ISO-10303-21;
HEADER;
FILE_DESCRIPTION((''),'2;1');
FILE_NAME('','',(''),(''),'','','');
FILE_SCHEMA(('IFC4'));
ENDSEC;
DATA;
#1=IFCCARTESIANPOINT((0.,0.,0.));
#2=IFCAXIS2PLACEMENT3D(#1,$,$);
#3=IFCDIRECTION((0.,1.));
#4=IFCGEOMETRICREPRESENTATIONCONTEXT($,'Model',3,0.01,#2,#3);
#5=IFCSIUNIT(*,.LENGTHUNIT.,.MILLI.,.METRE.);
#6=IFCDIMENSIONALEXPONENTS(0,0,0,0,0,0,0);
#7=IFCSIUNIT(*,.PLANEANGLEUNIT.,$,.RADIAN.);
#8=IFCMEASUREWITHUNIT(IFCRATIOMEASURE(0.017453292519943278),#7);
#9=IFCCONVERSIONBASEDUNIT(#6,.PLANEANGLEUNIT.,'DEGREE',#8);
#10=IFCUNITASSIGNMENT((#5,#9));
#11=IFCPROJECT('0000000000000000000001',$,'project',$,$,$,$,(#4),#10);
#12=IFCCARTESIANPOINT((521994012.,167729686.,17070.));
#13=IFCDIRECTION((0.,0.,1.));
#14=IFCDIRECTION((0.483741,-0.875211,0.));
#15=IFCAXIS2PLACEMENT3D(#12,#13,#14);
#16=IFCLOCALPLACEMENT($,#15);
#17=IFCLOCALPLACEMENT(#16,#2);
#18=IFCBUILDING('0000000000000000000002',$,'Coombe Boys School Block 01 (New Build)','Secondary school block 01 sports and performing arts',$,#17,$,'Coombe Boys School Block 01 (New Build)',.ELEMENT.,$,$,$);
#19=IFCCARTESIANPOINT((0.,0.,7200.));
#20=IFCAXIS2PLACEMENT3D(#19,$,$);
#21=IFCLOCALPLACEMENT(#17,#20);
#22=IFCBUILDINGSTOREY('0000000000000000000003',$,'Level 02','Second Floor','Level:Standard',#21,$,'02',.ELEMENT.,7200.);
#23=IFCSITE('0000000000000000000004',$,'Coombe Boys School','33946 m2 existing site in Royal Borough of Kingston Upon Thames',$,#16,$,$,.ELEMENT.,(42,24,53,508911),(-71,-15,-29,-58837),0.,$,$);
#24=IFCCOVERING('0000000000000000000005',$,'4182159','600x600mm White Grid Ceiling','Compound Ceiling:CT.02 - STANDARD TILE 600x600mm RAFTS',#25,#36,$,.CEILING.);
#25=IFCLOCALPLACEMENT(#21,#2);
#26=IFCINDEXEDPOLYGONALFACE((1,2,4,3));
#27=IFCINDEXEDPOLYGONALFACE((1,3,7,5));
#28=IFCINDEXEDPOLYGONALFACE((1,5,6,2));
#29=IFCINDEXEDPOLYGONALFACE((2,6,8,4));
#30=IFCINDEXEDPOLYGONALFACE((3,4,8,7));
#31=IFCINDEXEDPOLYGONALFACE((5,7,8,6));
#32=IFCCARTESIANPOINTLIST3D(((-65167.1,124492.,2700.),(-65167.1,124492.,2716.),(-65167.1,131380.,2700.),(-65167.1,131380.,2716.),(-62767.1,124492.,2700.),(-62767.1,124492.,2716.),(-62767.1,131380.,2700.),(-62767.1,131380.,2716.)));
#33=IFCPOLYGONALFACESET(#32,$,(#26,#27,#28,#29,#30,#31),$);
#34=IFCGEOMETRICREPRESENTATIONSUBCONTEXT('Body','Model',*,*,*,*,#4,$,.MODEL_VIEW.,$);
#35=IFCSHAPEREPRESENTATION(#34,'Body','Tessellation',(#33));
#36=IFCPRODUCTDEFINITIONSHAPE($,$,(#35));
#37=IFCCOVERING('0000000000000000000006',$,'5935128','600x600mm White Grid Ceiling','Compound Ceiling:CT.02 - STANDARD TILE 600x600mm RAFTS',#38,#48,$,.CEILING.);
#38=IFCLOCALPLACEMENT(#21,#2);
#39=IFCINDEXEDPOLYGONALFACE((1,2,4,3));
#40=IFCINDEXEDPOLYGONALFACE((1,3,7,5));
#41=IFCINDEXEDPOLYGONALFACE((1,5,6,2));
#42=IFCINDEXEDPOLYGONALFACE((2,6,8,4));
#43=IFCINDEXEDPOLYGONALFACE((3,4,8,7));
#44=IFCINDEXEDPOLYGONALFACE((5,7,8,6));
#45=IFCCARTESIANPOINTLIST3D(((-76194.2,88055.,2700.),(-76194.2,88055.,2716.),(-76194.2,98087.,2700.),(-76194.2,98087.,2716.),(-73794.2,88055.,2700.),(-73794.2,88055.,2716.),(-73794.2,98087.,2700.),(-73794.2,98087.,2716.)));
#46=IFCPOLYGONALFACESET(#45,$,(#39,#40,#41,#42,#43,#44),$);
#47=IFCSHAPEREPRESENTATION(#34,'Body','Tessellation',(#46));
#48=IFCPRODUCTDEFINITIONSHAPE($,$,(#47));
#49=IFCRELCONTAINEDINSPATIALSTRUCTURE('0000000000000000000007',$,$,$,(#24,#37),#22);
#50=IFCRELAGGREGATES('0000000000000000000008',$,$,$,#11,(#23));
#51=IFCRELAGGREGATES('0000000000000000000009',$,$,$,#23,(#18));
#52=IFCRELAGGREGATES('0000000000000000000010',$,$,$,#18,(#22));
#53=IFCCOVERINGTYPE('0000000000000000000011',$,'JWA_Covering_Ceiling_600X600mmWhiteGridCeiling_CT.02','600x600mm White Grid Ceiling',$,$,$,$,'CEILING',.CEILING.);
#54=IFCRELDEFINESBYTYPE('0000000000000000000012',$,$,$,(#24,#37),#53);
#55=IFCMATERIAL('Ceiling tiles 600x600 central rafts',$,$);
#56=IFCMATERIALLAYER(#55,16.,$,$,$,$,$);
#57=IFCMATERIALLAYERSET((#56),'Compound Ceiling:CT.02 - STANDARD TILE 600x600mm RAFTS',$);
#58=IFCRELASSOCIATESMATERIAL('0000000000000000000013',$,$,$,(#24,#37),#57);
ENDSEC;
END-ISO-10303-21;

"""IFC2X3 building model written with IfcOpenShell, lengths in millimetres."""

from ifc_helpers import new_model, entity, si_unit, converted_unit, direction, frame, frame_2d, origin, place, context, subcontext, project, spatial, rectangle, extrude, material, layer, layer_set, layer_usage, type_object, element, save


model = new_model("IFC2X3")

# Units and contexts
model_context = context("Model", 3, precision=0.01, world=origin(), true_north=direction((0.0, 1.0)))
body_context = subcontext(model_context, "Body", "Model", "MODEL_VIEW")
ifc_project = project(units=[si_unit("LENGTHUNIT", "METRE", prefix="MILLI"), converted_unit("PLANEANGLEUNIT", "DEGREE", entity("IfcRatioMeasure", 0.017453292519943278), si_unit("PLANEANGLEUNIT", "RADIAN"), dimensions=[0, 0, 0, 0, 0, 0, 0])], contexts=[model_context])

# Site, building, storey
site_placement = place(None, frame((521994012.0, 167729686.0, 17070.0), z_axis=(0.0, 0.0, 1.0), x_axis=(0.483741, -0.875211, 0.0)))
site = spatial("IfcSite", under=ifc_project, at=site_placement, Name="Coombe Boys School", Description="33946 m2 existing site in Royal Borough of Kingston Upon Thames", CompositionType="ELEMENT", RefLatitude=(42, 24, 53, 508911), RefLongitude=(-71, -15, -29, -58837), RefElevation=0.0)
building_placement = place(site_placement, origin())
building = spatial("IfcBuilding", under=site, at=building_placement, Name="Coombe Boys School Block 01 (New Build)", Description="Secondary school block 01 sports and performing arts", LongName="Coombe Boys School Block 01 (New Build)", CompositionType="ELEMENT")
storey_placement = place(building_placement, frame((0.0, 0.0, 7200.0)))
storey = spatial("IfcBuildingStorey", under=building, at=storey_placement, Name="Level 02", Description="Second Floor", ObjectType="Level:Standard", LongName="02", CompositionType="ELEMENT", Elevation=7200.0)

# Coverings
ifc_material_1 = material(Name="Ceiling tiles 600x600 central rafts")
ifc_layer_1 = layer(ifc_material_1, 16.0)
ifc_layer_set_1 = layer_set([ifc_layer_1], Name="Compound Ceiling:CT.02 - STANDARD TILE 600x600mm RAFTS")
ifc_layer_usage_1 = layer_usage(ifc_layer_set_1, "AXIS3", "POSITIVE", 0.0)
covering_type_1 = type_object("IfcCoveringType", Name="JWA_Covering_Ceiling_600X600mmWhiteGridCeiling_CT.02", Description="600x600mm White Grid Ceiling", ElementType="CEILING", PredefinedType="CEILING")
covering_1_placement = place(storey_placement, origin())
element("IfcCovering", 1, at=covering_1_placement, inside=storey, type_object=covering_type_1, material=ifc_layer_usage_1, Name="4182159", Description="600x600mm White Grid Ceiling", ObjectType="Compound Ceiling:CT.02 - STANDARD TILE 600x600mm RAFTS", PredefinedType="CEILING", context=body_context, shape_type="SweptSolid", body=[
    extrude(rectangle(XDim=2400.0, YDim=6888.0, at=frame_2d((0.0, 0.0), x_axis=(1.0, 0.0))), frame((-63967.1, 127936.0, 2700.0), z_axis=(0.0, 0.0, 1.0), x_axis=(-1.0, 0.0, 0.0)), (0.0, 0.0, 1.0), 16.0),
])
covering_2_placement = place(storey_placement, origin())
element("IfcCovering", 2, at=covering_2_placement, inside=storey, type_object=covering_type_1, material=ifc_layer_usage_1, Name="5935128", Description="600x600mm White Grid Ceiling", ObjectType="Compound Ceiling:CT.02 - STANDARD TILE 600x600mm RAFTS", PredefinedType="CEILING", context=body_context, shape_type="SweptSolid", body=[
    extrude(rectangle(XDim=10032.0, YDim=2400.0, at=frame_2d((0.0, 0.0), x_axis=(1.0, 0.0))), frame((-74994.2, 93071.0, 2700.0), z_axis=(0.0, 0.0, 1.0), x_axis=(0.0, 1.0, 0.0)), (0.0, 0.0, 1.0), 16.0),
])

save(model, "model.ifc")
